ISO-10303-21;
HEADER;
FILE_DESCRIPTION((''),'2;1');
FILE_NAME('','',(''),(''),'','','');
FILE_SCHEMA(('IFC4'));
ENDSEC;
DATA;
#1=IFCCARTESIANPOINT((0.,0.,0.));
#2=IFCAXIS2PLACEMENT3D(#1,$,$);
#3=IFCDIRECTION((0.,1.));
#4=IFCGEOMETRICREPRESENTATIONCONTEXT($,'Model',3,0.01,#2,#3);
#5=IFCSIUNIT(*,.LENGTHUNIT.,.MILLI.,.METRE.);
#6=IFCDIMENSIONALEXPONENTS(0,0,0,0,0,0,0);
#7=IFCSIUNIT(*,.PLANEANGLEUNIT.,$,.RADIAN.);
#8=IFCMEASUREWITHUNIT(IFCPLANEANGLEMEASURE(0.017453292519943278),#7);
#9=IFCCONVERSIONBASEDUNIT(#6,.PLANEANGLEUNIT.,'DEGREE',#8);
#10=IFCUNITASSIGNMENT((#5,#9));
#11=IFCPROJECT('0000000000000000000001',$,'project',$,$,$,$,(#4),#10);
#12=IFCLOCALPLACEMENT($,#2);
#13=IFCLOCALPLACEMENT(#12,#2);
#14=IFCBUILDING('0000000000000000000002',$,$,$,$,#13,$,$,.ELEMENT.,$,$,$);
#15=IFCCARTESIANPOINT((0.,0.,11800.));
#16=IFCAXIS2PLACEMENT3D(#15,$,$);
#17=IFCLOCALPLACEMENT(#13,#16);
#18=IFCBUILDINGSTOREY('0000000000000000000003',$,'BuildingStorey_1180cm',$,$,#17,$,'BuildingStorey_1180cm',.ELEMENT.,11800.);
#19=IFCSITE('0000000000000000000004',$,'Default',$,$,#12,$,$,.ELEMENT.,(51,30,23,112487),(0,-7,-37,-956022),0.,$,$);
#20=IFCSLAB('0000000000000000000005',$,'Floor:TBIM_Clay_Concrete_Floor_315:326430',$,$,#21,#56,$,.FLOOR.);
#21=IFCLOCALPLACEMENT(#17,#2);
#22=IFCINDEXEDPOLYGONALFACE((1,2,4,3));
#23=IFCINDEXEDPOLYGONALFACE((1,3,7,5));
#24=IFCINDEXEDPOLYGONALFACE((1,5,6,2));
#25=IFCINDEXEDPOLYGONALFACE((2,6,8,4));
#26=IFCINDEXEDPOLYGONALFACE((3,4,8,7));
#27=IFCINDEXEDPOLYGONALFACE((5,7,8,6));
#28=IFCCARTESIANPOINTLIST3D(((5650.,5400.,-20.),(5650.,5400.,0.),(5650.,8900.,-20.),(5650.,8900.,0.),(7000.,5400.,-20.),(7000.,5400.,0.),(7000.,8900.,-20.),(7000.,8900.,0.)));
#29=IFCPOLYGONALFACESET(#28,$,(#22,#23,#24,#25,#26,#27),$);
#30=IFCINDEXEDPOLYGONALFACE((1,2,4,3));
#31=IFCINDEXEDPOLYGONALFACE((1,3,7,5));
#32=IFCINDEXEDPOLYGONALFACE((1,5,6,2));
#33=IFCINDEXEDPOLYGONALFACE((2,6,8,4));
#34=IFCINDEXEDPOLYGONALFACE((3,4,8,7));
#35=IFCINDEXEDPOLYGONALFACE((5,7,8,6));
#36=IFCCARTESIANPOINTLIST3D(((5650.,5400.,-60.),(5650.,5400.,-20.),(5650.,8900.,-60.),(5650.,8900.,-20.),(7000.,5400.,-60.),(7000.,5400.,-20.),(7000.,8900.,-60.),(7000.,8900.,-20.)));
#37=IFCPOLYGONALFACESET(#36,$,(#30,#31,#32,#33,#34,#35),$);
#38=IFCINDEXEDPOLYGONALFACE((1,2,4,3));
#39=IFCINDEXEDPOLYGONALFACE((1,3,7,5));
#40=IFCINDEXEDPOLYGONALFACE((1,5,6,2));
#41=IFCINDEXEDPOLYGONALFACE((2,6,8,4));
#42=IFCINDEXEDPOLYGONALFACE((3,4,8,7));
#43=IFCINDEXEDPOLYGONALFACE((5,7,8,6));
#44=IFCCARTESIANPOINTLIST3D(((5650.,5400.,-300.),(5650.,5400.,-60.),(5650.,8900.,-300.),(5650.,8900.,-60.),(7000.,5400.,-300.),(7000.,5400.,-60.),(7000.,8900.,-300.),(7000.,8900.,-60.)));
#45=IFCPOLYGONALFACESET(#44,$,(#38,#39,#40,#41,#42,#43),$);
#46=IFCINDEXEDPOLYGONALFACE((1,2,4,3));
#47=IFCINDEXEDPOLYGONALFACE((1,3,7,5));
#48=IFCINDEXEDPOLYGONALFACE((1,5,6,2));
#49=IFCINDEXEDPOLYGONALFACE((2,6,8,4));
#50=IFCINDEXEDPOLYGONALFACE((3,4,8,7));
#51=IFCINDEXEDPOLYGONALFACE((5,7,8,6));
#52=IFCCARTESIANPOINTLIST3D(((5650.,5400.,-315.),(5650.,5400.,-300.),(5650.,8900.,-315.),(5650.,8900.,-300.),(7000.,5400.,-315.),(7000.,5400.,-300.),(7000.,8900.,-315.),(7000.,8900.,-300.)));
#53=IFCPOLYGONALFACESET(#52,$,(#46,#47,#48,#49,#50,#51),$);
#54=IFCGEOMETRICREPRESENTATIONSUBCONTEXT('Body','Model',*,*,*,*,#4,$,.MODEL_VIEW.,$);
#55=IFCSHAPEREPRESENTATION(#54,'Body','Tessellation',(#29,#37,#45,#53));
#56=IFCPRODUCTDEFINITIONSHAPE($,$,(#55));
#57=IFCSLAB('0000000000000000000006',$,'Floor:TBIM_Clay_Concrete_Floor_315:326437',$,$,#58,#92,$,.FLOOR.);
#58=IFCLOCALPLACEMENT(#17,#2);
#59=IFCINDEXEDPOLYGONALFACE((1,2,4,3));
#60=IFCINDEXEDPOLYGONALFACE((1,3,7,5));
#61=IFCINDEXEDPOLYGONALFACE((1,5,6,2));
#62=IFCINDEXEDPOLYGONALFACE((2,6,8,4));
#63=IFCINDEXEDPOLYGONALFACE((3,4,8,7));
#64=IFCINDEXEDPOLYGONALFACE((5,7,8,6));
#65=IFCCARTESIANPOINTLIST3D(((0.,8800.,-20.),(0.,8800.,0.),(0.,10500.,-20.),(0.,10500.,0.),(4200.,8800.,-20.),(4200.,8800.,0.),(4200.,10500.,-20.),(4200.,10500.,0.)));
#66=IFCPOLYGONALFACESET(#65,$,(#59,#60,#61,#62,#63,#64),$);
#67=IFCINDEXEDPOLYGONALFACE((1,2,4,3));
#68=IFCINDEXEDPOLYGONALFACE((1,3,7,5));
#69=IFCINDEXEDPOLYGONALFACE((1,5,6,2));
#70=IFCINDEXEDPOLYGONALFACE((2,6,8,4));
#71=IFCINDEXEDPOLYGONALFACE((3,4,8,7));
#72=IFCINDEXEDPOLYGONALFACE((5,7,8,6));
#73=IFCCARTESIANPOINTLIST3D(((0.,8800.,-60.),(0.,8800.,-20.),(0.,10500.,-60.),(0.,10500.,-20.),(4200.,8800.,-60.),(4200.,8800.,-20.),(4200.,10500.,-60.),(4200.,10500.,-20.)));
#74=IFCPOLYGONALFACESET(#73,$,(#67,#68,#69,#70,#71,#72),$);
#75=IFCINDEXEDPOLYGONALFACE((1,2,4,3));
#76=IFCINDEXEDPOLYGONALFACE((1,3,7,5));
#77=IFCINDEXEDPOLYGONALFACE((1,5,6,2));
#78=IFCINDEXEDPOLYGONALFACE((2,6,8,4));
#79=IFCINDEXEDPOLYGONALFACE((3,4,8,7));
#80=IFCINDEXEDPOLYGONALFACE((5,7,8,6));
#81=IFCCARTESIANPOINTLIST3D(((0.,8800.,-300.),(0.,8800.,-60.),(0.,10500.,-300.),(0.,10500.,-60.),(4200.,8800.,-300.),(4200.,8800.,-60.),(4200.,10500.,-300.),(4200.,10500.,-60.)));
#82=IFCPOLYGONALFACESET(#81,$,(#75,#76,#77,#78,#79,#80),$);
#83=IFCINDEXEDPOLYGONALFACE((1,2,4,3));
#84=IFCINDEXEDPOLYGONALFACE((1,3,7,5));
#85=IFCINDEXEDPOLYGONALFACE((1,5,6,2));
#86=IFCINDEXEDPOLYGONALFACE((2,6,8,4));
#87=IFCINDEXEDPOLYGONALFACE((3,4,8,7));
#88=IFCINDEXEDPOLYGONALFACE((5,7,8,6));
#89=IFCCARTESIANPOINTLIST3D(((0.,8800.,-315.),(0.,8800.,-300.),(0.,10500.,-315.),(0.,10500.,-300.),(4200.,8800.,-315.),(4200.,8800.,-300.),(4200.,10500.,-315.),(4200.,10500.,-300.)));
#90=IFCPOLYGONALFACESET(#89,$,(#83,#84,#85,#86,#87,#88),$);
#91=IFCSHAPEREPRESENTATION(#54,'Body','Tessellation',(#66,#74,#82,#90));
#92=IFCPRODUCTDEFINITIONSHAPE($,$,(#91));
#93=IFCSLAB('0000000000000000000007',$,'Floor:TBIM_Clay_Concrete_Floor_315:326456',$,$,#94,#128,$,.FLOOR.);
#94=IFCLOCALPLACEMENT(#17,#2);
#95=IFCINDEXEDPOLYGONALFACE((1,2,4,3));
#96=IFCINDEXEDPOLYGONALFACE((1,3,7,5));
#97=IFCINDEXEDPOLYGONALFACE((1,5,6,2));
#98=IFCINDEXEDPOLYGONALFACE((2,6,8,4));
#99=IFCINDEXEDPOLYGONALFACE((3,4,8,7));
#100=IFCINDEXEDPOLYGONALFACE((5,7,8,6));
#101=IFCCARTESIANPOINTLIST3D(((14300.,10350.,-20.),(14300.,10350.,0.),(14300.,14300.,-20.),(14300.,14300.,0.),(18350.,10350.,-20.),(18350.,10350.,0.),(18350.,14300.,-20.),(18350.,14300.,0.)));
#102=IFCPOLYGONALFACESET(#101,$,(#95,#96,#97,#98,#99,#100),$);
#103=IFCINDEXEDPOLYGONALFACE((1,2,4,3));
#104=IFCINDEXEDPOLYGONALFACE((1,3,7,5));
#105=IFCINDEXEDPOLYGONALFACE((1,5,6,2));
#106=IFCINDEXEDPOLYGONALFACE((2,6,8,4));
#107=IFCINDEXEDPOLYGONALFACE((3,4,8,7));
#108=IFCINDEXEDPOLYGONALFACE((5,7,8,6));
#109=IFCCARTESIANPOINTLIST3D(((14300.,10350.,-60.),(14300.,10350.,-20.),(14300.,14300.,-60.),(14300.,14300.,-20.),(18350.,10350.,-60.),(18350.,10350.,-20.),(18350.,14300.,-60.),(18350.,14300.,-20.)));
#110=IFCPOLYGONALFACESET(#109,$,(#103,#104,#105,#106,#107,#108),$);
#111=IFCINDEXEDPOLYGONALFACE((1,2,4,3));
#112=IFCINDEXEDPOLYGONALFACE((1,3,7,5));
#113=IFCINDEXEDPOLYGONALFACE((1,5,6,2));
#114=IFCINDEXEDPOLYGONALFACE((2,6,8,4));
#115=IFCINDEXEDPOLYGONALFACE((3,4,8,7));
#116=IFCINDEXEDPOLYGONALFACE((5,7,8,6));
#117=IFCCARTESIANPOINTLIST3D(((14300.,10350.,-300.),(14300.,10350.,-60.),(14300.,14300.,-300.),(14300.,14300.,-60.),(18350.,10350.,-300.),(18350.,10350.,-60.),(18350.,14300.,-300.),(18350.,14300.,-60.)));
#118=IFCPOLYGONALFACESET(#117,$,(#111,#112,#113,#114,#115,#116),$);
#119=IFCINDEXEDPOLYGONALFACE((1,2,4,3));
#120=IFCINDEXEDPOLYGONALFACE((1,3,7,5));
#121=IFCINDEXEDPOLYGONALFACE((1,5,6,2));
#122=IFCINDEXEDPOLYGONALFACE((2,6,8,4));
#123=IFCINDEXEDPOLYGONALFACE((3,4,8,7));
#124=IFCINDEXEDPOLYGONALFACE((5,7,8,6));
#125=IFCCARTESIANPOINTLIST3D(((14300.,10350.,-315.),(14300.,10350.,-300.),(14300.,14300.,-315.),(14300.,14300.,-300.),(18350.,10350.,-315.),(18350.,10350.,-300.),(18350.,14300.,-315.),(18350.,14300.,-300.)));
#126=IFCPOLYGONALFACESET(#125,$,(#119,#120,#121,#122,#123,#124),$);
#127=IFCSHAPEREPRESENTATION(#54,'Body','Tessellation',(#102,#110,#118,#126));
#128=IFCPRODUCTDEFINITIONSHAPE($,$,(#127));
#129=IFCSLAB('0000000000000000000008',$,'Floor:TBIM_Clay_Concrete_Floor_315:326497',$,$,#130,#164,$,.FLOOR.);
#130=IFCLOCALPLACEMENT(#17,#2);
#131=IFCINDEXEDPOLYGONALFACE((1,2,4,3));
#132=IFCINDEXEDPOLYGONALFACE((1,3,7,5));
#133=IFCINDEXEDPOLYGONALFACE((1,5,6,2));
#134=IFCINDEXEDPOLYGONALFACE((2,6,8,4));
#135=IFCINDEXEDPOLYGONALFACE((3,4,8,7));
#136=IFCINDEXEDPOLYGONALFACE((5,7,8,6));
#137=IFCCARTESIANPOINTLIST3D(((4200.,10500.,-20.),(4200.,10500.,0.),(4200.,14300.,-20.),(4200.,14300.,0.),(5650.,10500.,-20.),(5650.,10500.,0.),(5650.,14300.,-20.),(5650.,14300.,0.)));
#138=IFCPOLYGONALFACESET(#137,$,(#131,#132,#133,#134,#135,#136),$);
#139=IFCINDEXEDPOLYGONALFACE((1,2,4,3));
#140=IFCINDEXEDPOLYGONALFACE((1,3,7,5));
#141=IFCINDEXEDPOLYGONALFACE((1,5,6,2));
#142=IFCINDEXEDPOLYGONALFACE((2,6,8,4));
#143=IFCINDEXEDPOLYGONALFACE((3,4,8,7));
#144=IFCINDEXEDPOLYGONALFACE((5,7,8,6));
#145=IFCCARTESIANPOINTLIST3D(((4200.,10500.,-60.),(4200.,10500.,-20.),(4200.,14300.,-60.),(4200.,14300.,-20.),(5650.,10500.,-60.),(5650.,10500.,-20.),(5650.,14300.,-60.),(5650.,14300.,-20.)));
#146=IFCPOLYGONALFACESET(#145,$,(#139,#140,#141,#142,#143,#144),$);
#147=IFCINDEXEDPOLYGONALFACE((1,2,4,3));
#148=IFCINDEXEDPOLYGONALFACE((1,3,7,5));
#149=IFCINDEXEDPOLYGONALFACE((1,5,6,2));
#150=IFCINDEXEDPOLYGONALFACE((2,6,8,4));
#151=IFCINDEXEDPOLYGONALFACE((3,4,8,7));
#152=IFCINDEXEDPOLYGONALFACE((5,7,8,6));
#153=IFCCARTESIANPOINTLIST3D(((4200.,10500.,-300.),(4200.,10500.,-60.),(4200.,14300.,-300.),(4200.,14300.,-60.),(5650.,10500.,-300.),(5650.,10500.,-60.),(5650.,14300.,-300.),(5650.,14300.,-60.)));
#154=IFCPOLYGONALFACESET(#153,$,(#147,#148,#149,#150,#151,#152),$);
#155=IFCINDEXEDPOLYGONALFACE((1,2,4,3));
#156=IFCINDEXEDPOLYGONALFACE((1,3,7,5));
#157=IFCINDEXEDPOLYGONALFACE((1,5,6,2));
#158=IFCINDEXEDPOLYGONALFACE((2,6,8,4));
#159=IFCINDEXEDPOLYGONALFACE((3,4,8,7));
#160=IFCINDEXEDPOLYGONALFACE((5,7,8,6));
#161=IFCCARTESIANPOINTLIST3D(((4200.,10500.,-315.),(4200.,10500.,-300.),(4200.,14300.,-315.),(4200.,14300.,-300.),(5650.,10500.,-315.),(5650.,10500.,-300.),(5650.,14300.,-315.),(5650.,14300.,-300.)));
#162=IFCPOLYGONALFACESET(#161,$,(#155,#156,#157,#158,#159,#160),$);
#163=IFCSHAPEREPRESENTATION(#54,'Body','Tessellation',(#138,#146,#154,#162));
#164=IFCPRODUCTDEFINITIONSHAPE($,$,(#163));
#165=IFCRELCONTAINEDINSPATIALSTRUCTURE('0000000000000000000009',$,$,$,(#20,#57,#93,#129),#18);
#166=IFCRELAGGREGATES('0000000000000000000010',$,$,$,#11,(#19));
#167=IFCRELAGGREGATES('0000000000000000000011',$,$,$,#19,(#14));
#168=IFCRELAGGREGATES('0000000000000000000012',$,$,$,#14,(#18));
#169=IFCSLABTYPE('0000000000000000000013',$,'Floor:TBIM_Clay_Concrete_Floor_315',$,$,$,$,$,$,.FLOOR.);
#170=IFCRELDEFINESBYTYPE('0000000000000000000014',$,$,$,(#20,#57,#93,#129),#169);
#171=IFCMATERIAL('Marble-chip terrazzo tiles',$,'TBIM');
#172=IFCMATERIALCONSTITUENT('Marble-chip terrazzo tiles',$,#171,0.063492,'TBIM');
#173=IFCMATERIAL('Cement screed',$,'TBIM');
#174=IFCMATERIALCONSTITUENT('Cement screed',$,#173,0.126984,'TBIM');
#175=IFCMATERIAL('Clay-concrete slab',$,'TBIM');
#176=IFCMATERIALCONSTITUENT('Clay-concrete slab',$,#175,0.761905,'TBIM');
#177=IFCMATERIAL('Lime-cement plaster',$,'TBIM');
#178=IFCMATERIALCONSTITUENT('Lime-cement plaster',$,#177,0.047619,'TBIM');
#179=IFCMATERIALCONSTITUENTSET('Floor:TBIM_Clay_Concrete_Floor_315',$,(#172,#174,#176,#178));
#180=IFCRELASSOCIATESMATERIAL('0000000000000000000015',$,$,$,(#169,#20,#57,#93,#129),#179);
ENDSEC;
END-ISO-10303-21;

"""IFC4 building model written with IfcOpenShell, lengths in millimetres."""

from ifc_helpers import new_model, entity, si_unit, converted_unit, direction, frame, origin, place, context, subcontext, project, spatial, indexed_curve, outline, extrude, material, constituent, constituent_set, type_object, element, save


model = new_model("IFC4")

# Units and contexts
model_context = context("Model", 3, precision=0.01, world=origin(), true_north=direction((0.0, 1.0)))
body_context = subcontext(model_context, "Body", "Model", "MODEL_VIEW")
ifc_project = project(units=[si_unit("LENGTHUNIT", "METRE", prefix="MILLI"), converted_unit("PLANEANGLEUNIT", "DEGREE", entity("IfcPlaneAngleMeasure", 0.017453292519943278), si_unit("PLANEANGLEUNIT", "RADIAN"), dimensions=[0, 0, 0, 0, 0, 0, 0])], contexts=[model_context])

# Site, building, storey
site_placement = place(None, origin())
site = spatial("IfcSite", under=ifc_project, at=site_placement, Name="Default", CompositionType="ELEMENT", RefLatitude=(51, 30, 23, 112487), RefLongitude=(0, -7, -37, -956022), RefElevation=0.0)
building_placement = place(site_placement, origin())
building = spatial("IfcBuilding", under=site, at=building_placement, CompositionType="ELEMENT")
storey_placement = place(building_placement, frame((0.0, 0.0, 11800.0)))
storey = spatial("IfcBuildingStorey", under=building, at=storey_placement, Name="BuildingStorey_1180cm", LongName="BuildingStorey_1180cm", CompositionType="ELEMENT", Elevation=11800.0)

# Slabs
ifc_material_1 = material(Name="Marble-chip terrazzo tiles", Category="TBIM")
ifc_constituent_1 = constituent(ifc_material_1, Name="Marble-chip terrazzo tiles", Category="TBIM", fraction=0.063492)
ifc_material_2 = material(Name="Cement screed", Category="TBIM")
ifc_constituent_2 = constituent(ifc_material_2, Name="Cement screed", Category="TBIM", fraction=0.126984)
ifc_material_3 = material(Name="Clay-concrete slab", Category="TBIM")
ifc_constituent_3 = constituent(ifc_material_3, Name="Clay-concrete slab", Category="TBIM", fraction=0.761905)
ifc_material_4 = material(Name="Lime-cement plaster", Category="TBIM")
ifc_constituent_4 = constituent(ifc_material_4, Name="Lime-cement plaster", Category="TBIM", fraction=0.047619)
ifc_constituent_set_1 = constituent_set(constituents=[ifc_constituent_1, ifc_constituent_2, ifc_constituent_3, ifc_constituent_4], Name="Floor:TBIM_Clay_Concrete_Floor_315")
slab_type = type_object("IfcSlabType", Name="Floor:TBIM_Clay_Concrete_Floor_315", PredefinedType="FLOOR", material=ifc_constituent_set_1)
slab_1_placement = place(storey_placement, origin())
element("IfcSlab", 1, at=slab_1_placement, inside=storey, type_object=slab_type, material=ifc_constituent_set_1, Name="Floor:TBIM_Clay_Concrete_Floor_315:326430", PredefinedType="FLOOR", context=body_context, shape_type="SweptSolid", body=[
    extrude(outline(indexed_curve([(-675.0, -1750.0), (675.0, -1750.0), (675.0, 1750.0), (-675.0, 1750.0), (-675.0, -1750.0)], self_intersect=False)), frame((6325.0, 7150.0, -20.0), z_axis=(0.0, 0.0, 1.0), x_axis=(-1.0, 0.0, 0.0)), (0.0, 0.0, 1.0), 20.0),
    extrude(outline(indexed_curve([(-675.0, -1750.0), (675.0, -1750.0), (675.0, 1750.0), (-675.0, 1750.0), (-675.0, -1750.0)], self_intersect=False)), frame((6325.0, 7150.0, -60.0), z_axis=(0.0, 0.0, 1.0), x_axis=(-1.0, 0.0, 0.0)), (0.0, 0.0, 1.0), 40.0),
    extrude(outline(indexed_curve([(-675.0, -1750.0), (675.0, -1750.0), (675.0, 1750.0), (-675.0, 1750.0), (-675.0, -1750.0)], self_intersect=False)), frame((6325.0, 7150.0, -300.0), z_axis=(0.0, 0.0, 1.0), x_axis=(-1.0, 0.0, 0.0)), (0.0, 0.0, 1.0), 240.0),
    extrude(outline(indexed_curve([(-675.0, -1750.0), (675.0, -1750.0), (675.0, 1750.0), (-675.0, 1750.0), (-675.0, -1750.0)], self_intersect=False)), frame((6325.0, 7150.0, -315.0), z_axis=(0.0, 0.0, 1.0), x_axis=(-1.0, 0.0, 0.0)), (0.0, 0.0, 1.0), 15.0),
])
slab_2_placement = place(storey_placement, origin())
element("IfcSlab", 2, at=slab_2_placement, inside=storey, type_object=slab_type, material=ifc_constituent_set_1, Name="Floor:TBIM_Clay_Concrete_Floor_315:326437", PredefinedType="FLOOR", context=body_context, shape_type="SweptSolid", body=[
    extrude(outline(indexed_curve([(-2100.0, -850.0), (2100.0, -850.0), (2100.0, 850.0), (-2100.0, 850.0), (-2100.0, -850.0)], self_intersect=False)), frame((2100.0, 9650.0, -20.0), z_axis=(0.0, 0.0, 1.0), x_axis=(-1.0, 0.0, 0.0)), (0.0, 0.0, 1.0), 20.0),
    extrude(outline(indexed_curve([(-2100.0, -850.0), (2100.0, -850.0), (2100.0, 850.0), (-2100.0, 850.0), (-2100.0, -850.0)], self_intersect=False)), frame((2100.0, 9650.0, -60.0), z_axis=(0.0, 0.0, 1.0), x_axis=(-1.0, 0.0, 0.0)), (0.0, 0.0, 1.0), 40.0),
    extrude(outline(indexed_curve([(-2100.0, -850.0), (2100.0, -850.0), (2100.0, 850.0), (-2100.0, 850.0), (-2100.0, -850.0)], self_intersect=False)), frame((2100.0, 9650.0, -300.0), z_axis=(0.0, 0.0, 1.0), x_axis=(-1.0, 0.0, 0.0)), (0.0, 0.0, 1.0), 240.0),
    extrude(outline(indexed_curve([(-2100.0, -850.0), (2100.0, -850.0), (2100.0, 850.0), (-2100.0, 850.0), (-2100.0, -850.0)], self_intersect=False)), frame((2100.0, 9650.0, -315.0), z_axis=(0.0, 0.0, 1.0), x_axis=(-1.0, 0.0, 0.0)), (0.0, 0.0, 1.0), 15.0),
])
slab_3_placement = place(storey_placement, origin())
element("IfcSlab", 3, at=slab_3_placement, inside=storey, type_object=slab_type, material=ifc_constituent_set_1, Name="Floor:TBIM_Clay_Concrete_Floor_315:326456", PredefinedType="FLOOR", context=body_context, shape_type="SweptSolid", body=[
    extrude(outline(indexed_curve([(-2025.0, -1975.0), (2025.0, -1975.0), (2025.0, 1975.0), (-2025.0, 1975.0), (-2025.0, -1975.0)], self_intersect=False)), frame((16325.0, 12325.0, -20.0), z_axis=(0.0, 0.0, 1.0), x_axis=(-1.0, 0.0, 0.0)), (0.0, 0.0, 1.0), 20.0),
    extrude(outline(indexed_curve([(-2025.0, -1975.0), (2025.0, -1975.0), (2025.0, 1975.0), (-2025.0, 1975.0), (-2025.0, -1975.0)], self_intersect=False)), frame((16325.0, 12325.0, -60.0), z_axis=(0.0, 0.0, 1.0), x_axis=(-1.0, 0.0, 0.0)), (0.0, 0.0, 1.0), 40.0),
    extrude(outline(indexed_curve([(-2025.0, -1975.0), (2025.0, -1975.0), (2025.0, 1975.0), (-2025.0, 1975.0), (-2025.0, -1975.0)], self_intersect=False)), frame((16325.0, 12325.0, -300.0), z_axis=(0.0, 0.0, 1.0), x_axis=(-1.0, 0.0, 0.0)), (0.0, 0.0, 1.0), 240.0),
    extrude(outline(indexed_curve([(-2025.0, -1975.0), (2025.0, -1975.0), (2025.0, 1975.0), (-2025.0, 1975.0), (-2025.0, -1975.0)], self_intersect=False)), frame((16325.0, 12325.0, -315.0), z_axis=(0.0, 0.0, 1.0), x_axis=(-1.0, 0.0, 0.0)), (0.0, 0.0, 1.0), 15.0),
])
slab_4_placement = place(storey_placement, origin())
element("IfcSlab", 4, at=slab_4_placement, inside=storey, type_object=slab_type, material=ifc_constituent_set_1, Name="Floor:TBIM_Clay_Concrete_Floor_315:326497", PredefinedType="FLOOR", context=body_context, shape_type="SweptSolid", body=[
    extrude(outline(indexed_curve([(-725.0, -1900.0), (725.0, -1900.0), (725.0, 1900.0), (-725.0, 1900.0), (-725.0, -1900.0)], self_intersect=False)), frame((4925.0, 12400.0, -20.0), z_axis=(0.0, 0.0, 1.0), x_axis=(-1.0, 0.0, 0.0)), (0.0, 0.0, 1.0), 20.0),
    extrude(outline(indexed_curve([(-725.0, -1900.0), (725.0, -1900.0), (725.0, 1900.0), (-725.0, 1900.0), (-725.0, -1900.0)], self_intersect=False)), frame((4925.0, 12400.0, -60.0), z_axis=(0.0, 0.0, 1.0), x_axis=(-1.0, 0.0, 0.0)), (0.0, 0.0, 1.0), 40.0),
    extrude(outline(indexed_curve([(-725.0, -1900.0), (725.0, -1900.0), (725.0, 1900.0), (-725.0, 1900.0), (-725.0, -1900.0)], self_intersect=False)), frame((4925.0, 12400.0, -300.0), z_axis=(0.0, 0.0, 1.0), x_axis=(-1.0, 0.0, 0.0)), (0.0, 0.0, 1.0), 240.0),
    extrude(outline(indexed_curve([(-725.0, -1900.0), (725.0, -1900.0), (725.0, 1900.0), (-725.0, 1900.0), (-725.0, -1900.0)], self_intersect=False)), frame((4925.0, 12400.0, -315.0), z_axis=(0.0, 0.0, 1.0), x_axis=(-1.0, 0.0, 0.0)), (0.0, 0.0, 1.0), 15.0),
])

save(model, "model.ifc")
